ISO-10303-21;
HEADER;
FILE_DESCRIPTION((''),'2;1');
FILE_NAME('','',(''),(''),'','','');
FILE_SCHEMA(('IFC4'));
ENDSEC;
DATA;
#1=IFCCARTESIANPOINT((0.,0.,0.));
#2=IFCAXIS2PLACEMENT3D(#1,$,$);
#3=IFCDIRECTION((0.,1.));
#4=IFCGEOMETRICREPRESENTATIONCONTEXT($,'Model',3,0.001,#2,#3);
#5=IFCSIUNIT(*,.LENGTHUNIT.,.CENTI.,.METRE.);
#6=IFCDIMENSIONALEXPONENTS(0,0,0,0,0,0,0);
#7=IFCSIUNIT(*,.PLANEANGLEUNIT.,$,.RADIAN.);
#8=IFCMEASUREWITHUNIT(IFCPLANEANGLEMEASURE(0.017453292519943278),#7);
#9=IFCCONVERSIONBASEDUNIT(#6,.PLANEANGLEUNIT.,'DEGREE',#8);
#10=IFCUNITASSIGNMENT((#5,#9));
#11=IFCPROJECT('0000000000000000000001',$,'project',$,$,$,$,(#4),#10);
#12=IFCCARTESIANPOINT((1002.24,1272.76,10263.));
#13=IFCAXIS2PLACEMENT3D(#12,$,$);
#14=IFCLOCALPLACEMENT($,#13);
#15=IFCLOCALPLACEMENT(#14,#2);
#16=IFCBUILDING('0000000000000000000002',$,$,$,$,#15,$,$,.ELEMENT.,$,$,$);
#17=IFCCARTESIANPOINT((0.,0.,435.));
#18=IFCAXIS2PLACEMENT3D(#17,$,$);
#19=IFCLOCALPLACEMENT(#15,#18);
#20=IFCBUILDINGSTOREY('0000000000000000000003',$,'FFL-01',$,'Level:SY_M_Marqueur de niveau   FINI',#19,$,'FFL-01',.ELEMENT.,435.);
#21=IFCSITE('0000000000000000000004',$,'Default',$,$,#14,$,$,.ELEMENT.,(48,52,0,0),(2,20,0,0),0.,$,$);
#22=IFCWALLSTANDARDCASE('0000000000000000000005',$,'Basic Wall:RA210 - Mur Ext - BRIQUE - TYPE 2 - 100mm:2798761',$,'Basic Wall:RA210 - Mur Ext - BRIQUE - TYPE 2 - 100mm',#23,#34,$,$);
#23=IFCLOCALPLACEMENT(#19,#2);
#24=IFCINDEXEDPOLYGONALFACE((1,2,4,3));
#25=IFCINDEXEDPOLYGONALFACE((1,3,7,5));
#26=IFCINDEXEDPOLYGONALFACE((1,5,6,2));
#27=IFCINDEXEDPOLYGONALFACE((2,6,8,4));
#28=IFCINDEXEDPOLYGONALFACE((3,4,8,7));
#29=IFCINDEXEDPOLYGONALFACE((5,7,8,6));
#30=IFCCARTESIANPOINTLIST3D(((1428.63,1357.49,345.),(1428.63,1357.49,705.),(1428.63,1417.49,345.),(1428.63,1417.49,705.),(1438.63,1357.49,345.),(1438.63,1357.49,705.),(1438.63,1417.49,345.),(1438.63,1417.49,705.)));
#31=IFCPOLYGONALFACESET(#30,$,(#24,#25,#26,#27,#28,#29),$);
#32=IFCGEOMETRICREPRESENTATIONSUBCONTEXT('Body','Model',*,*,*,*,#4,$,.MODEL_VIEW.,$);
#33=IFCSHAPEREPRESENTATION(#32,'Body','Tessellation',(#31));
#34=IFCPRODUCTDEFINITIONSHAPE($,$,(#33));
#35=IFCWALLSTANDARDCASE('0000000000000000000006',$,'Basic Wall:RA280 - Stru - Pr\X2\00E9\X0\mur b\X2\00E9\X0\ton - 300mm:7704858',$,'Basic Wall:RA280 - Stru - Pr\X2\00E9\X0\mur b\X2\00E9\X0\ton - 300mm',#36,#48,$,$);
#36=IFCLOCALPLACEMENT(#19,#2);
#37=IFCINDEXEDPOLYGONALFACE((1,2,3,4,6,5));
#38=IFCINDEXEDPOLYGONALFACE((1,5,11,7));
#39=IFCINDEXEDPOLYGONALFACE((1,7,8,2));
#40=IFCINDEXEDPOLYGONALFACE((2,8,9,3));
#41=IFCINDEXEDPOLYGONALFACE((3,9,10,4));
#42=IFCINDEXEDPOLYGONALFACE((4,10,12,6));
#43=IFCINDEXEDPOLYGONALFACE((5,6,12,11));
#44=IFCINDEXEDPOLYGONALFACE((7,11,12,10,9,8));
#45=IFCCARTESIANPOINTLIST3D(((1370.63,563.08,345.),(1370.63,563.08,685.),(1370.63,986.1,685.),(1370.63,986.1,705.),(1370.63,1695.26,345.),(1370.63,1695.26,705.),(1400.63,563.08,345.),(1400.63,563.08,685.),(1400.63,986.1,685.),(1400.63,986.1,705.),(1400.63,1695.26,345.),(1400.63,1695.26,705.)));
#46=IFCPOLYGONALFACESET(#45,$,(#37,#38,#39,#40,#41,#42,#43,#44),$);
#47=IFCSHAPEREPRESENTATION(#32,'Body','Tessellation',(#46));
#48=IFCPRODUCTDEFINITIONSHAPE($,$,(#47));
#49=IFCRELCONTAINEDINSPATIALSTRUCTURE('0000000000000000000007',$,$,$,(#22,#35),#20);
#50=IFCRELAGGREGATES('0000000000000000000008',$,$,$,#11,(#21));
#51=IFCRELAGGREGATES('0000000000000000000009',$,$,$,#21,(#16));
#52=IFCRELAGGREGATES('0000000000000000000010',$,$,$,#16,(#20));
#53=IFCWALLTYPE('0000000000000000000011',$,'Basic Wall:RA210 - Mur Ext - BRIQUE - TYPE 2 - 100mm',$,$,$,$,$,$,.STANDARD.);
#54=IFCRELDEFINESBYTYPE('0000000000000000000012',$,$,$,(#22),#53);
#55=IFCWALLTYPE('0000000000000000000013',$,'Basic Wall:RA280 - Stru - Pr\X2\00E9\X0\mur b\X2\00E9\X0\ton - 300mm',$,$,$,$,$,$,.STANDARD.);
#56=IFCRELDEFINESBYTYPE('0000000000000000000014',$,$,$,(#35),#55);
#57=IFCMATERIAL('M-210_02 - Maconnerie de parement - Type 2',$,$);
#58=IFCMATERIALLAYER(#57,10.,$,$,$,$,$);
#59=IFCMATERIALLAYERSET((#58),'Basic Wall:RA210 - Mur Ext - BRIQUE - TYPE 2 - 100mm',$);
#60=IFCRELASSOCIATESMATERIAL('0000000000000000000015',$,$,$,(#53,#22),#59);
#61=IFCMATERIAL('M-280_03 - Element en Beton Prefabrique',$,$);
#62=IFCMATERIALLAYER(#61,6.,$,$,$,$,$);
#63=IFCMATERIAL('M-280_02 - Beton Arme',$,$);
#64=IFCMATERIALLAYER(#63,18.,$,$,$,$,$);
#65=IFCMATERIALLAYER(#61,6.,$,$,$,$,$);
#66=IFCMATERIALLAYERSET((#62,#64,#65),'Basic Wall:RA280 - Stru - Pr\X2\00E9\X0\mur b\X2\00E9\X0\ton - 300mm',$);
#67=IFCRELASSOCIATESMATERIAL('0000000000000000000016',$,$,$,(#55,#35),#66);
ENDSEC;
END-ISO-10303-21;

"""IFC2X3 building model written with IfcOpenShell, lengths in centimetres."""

from ifc_helpers import new_model, entity, si_unit, converted_unit, direction, frame, frame_2d, origin, place, context, subcontext, project, spatial, polyline, rectangle, extrude, clip, bounded_halfspace, material, layer, layer_set, layer_usage, type_object, element, save


model = new_model("IFC2X3")

# Units and contexts
model_context = context("Model", 3, precision=0.001, world=origin(), true_north=direction((0.0, 1.0)))
body_context = subcontext(model_context, "Body", "Model", "MODEL_VIEW")
ifc_project = project(units=[si_unit("LENGTHUNIT", "METRE", prefix="CENTI"), converted_unit("PLANEANGLEUNIT", "DEGREE", entity("IfcPlaneAngleMeasure", 0.017453292519943278), si_unit("PLANEANGLEUNIT", "RADIAN"), dimensions=[0, 0, 0, 0, 0, 0, 0])], contexts=[model_context])

# Site, building, storey
site_placement = place(None, frame((1002.24, 1272.76, 10263.0)))
site = spatial("IfcSite", under=ifc_project, at=site_placement, Name="Default", CompositionType="ELEMENT", RefLatitude=(48, 52, 0, 0), RefLongitude=(2, 20, 0, 0), RefElevation=0.0)
building_placement = place(site_placement, origin())
building = spatial("IfcBuilding", under=site, at=building_placement, CompositionType="ELEMENT")
storey_placement = place(building_placement, frame((0.0, 0.0, 435.0)))
storey = spatial("IfcBuildingStorey", under=building, at=storey_placement, Name="FFL-01", ObjectType="Level:SY_M_Marqueur de niveau   FINI", LongName="FFL-01", CompositionType="ELEMENT", Elevation=435.0)

# Shared definitions
ifc_material_1 = material(Name="M-280_02 - Beton Arme")

# Shared definitions
ifc_material_2 = material(Name="M-280_03 - Element en Beton Prefabrique")

# Walls
ifc_material_3 = material(Name="M-210_02 - Maconnerie de parement - Type 2")
ifc_layer_1 = layer(ifc_material_3, 10.0)
ifc_layer_set_1 = layer_set([ifc_layer_1], Name="Basic Wall:RA210 - Mur Ext - BRIQUE - TYPE 2 - 100mm")
ifc_layer_usage_1 = layer_usage(ifc_layer_set_1, "AXIS2", "POSITIVE", -5.0)
wall_type_1 = type_object("IfcWallType", Name="Basic Wall:RA210 - Mur Ext - BRIQUE - TYPE 2 - 100mm", PredefinedType="STANDARD", material=ifc_layer_set_1)
wall_1_placement = place(storey_placement, frame((1433.63, 1357.49, 345.0), z_axis=(0.0, 0.0, 1.0), x_axis=(0.0, 1.0, 0.0)))
element("IfcWallStandardCase", 1, at=wall_1_placement, inside=storey, type_object=wall_type_1, material=ifc_layer_usage_1, Name="Basic Wall:RA210 - Mur Ext - BRIQUE - TYPE 2 - 100mm:2798761", ObjectType="Basic Wall:RA210 - Mur Ext - BRIQUE - TYPE 2 - 100mm", context=body_context, shape_type="SweptSolid", body=[
    extrude(rectangle(XDim=60.0, YDim=10.0, at=frame_2d((30.0, 0.0), x_axis=(-1.0, 0.0))), origin(), (0.0, 0.0, 1.0), 360.0),
])
ifc_layer_2 = layer(ifc_material_2, 6.0)
ifc_layer_3 = layer(ifc_material_1, 18.0)
ifc_layer_4 = layer(ifc_material_2, 6.0)
ifc_layer_set_2 = layer_set([ifc_layer_2, ifc_layer_3, ifc_layer_4], Name="Basic Wall:RA280 - Stru - Prémur béton - 300mm")
ifc_layer_usage_2 = layer_usage(ifc_layer_set_2, "AXIS2", "NEGATIVE", 15.0)
wall_type_2 = type_object("IfcWallType", Name="Basic Wall:RA280 - Stru - Prémur béton - 300mm", PredefinedType="STANDARD", material=ifc_layer_set_2)
wall_2_placement = place(storey_placement, frame((1385.63, 1695.26, 345.0), z_axis=(0.0, 0.0, 1.0), x_axis=(0.0, -1.0, 0.0)))
element("IfcWallStandardCase", 2, at=wall_2_placement, inside=storey, type_object=wall_type_2, material=ifc_layer_usage_2, Name="Basic Wall:RA280 - Stru - Prémur béton - 300mm:7704858", ObjectType="Basic Wall:RA280 - Stru - Prémur béton - 300mm", context=body_context, shape_type="Clipping", body=[
    clip(clip(extrude(rectangle(XDim=1132.18, YDim=30.0, at=frame_2d((566.09, 0.0), x_axis=(-1.0, 0.0))), origin(), (0.0, 0.0, 1.0), 360.0), bounded_halfspace(frame((709.17, 15.0, 340.0), z_axis=(0.0, 0.0, -1.0), x_axis=(0.0, 1.0, 0.0)), True, frame((709.17, 15.0, 340.0), z_axis=(0.0, 0.0, -1.0), x_axis=(0.0, 1.0, 0.0)), polyline([(0.0, 0.0), (0.0, 423.02), (-30.0, 423.02), (-30.0, 396.5), (-30.0, 379.0), (-30.0, 0.0), (0.0, 0.0)]))), bounded_halfspace(frame((709.17, -15.0, 340.0), z_axis=(-1.0, 0.0, 0.0), x_axis=(0.0, 0.0, 1.0)), True, frame((709.17, -15.0, 340.0), z_axis=(-1.0, 0.0, 0.0), x_axis=(0.0, 0.0, 1.0)), polyline([(0.0, 0.0), (20.0, 0.0), (20.0, 30.0), (0.0, 30.0), (0.0, 0.0)]))),
])

save(model, "model.ifc")
